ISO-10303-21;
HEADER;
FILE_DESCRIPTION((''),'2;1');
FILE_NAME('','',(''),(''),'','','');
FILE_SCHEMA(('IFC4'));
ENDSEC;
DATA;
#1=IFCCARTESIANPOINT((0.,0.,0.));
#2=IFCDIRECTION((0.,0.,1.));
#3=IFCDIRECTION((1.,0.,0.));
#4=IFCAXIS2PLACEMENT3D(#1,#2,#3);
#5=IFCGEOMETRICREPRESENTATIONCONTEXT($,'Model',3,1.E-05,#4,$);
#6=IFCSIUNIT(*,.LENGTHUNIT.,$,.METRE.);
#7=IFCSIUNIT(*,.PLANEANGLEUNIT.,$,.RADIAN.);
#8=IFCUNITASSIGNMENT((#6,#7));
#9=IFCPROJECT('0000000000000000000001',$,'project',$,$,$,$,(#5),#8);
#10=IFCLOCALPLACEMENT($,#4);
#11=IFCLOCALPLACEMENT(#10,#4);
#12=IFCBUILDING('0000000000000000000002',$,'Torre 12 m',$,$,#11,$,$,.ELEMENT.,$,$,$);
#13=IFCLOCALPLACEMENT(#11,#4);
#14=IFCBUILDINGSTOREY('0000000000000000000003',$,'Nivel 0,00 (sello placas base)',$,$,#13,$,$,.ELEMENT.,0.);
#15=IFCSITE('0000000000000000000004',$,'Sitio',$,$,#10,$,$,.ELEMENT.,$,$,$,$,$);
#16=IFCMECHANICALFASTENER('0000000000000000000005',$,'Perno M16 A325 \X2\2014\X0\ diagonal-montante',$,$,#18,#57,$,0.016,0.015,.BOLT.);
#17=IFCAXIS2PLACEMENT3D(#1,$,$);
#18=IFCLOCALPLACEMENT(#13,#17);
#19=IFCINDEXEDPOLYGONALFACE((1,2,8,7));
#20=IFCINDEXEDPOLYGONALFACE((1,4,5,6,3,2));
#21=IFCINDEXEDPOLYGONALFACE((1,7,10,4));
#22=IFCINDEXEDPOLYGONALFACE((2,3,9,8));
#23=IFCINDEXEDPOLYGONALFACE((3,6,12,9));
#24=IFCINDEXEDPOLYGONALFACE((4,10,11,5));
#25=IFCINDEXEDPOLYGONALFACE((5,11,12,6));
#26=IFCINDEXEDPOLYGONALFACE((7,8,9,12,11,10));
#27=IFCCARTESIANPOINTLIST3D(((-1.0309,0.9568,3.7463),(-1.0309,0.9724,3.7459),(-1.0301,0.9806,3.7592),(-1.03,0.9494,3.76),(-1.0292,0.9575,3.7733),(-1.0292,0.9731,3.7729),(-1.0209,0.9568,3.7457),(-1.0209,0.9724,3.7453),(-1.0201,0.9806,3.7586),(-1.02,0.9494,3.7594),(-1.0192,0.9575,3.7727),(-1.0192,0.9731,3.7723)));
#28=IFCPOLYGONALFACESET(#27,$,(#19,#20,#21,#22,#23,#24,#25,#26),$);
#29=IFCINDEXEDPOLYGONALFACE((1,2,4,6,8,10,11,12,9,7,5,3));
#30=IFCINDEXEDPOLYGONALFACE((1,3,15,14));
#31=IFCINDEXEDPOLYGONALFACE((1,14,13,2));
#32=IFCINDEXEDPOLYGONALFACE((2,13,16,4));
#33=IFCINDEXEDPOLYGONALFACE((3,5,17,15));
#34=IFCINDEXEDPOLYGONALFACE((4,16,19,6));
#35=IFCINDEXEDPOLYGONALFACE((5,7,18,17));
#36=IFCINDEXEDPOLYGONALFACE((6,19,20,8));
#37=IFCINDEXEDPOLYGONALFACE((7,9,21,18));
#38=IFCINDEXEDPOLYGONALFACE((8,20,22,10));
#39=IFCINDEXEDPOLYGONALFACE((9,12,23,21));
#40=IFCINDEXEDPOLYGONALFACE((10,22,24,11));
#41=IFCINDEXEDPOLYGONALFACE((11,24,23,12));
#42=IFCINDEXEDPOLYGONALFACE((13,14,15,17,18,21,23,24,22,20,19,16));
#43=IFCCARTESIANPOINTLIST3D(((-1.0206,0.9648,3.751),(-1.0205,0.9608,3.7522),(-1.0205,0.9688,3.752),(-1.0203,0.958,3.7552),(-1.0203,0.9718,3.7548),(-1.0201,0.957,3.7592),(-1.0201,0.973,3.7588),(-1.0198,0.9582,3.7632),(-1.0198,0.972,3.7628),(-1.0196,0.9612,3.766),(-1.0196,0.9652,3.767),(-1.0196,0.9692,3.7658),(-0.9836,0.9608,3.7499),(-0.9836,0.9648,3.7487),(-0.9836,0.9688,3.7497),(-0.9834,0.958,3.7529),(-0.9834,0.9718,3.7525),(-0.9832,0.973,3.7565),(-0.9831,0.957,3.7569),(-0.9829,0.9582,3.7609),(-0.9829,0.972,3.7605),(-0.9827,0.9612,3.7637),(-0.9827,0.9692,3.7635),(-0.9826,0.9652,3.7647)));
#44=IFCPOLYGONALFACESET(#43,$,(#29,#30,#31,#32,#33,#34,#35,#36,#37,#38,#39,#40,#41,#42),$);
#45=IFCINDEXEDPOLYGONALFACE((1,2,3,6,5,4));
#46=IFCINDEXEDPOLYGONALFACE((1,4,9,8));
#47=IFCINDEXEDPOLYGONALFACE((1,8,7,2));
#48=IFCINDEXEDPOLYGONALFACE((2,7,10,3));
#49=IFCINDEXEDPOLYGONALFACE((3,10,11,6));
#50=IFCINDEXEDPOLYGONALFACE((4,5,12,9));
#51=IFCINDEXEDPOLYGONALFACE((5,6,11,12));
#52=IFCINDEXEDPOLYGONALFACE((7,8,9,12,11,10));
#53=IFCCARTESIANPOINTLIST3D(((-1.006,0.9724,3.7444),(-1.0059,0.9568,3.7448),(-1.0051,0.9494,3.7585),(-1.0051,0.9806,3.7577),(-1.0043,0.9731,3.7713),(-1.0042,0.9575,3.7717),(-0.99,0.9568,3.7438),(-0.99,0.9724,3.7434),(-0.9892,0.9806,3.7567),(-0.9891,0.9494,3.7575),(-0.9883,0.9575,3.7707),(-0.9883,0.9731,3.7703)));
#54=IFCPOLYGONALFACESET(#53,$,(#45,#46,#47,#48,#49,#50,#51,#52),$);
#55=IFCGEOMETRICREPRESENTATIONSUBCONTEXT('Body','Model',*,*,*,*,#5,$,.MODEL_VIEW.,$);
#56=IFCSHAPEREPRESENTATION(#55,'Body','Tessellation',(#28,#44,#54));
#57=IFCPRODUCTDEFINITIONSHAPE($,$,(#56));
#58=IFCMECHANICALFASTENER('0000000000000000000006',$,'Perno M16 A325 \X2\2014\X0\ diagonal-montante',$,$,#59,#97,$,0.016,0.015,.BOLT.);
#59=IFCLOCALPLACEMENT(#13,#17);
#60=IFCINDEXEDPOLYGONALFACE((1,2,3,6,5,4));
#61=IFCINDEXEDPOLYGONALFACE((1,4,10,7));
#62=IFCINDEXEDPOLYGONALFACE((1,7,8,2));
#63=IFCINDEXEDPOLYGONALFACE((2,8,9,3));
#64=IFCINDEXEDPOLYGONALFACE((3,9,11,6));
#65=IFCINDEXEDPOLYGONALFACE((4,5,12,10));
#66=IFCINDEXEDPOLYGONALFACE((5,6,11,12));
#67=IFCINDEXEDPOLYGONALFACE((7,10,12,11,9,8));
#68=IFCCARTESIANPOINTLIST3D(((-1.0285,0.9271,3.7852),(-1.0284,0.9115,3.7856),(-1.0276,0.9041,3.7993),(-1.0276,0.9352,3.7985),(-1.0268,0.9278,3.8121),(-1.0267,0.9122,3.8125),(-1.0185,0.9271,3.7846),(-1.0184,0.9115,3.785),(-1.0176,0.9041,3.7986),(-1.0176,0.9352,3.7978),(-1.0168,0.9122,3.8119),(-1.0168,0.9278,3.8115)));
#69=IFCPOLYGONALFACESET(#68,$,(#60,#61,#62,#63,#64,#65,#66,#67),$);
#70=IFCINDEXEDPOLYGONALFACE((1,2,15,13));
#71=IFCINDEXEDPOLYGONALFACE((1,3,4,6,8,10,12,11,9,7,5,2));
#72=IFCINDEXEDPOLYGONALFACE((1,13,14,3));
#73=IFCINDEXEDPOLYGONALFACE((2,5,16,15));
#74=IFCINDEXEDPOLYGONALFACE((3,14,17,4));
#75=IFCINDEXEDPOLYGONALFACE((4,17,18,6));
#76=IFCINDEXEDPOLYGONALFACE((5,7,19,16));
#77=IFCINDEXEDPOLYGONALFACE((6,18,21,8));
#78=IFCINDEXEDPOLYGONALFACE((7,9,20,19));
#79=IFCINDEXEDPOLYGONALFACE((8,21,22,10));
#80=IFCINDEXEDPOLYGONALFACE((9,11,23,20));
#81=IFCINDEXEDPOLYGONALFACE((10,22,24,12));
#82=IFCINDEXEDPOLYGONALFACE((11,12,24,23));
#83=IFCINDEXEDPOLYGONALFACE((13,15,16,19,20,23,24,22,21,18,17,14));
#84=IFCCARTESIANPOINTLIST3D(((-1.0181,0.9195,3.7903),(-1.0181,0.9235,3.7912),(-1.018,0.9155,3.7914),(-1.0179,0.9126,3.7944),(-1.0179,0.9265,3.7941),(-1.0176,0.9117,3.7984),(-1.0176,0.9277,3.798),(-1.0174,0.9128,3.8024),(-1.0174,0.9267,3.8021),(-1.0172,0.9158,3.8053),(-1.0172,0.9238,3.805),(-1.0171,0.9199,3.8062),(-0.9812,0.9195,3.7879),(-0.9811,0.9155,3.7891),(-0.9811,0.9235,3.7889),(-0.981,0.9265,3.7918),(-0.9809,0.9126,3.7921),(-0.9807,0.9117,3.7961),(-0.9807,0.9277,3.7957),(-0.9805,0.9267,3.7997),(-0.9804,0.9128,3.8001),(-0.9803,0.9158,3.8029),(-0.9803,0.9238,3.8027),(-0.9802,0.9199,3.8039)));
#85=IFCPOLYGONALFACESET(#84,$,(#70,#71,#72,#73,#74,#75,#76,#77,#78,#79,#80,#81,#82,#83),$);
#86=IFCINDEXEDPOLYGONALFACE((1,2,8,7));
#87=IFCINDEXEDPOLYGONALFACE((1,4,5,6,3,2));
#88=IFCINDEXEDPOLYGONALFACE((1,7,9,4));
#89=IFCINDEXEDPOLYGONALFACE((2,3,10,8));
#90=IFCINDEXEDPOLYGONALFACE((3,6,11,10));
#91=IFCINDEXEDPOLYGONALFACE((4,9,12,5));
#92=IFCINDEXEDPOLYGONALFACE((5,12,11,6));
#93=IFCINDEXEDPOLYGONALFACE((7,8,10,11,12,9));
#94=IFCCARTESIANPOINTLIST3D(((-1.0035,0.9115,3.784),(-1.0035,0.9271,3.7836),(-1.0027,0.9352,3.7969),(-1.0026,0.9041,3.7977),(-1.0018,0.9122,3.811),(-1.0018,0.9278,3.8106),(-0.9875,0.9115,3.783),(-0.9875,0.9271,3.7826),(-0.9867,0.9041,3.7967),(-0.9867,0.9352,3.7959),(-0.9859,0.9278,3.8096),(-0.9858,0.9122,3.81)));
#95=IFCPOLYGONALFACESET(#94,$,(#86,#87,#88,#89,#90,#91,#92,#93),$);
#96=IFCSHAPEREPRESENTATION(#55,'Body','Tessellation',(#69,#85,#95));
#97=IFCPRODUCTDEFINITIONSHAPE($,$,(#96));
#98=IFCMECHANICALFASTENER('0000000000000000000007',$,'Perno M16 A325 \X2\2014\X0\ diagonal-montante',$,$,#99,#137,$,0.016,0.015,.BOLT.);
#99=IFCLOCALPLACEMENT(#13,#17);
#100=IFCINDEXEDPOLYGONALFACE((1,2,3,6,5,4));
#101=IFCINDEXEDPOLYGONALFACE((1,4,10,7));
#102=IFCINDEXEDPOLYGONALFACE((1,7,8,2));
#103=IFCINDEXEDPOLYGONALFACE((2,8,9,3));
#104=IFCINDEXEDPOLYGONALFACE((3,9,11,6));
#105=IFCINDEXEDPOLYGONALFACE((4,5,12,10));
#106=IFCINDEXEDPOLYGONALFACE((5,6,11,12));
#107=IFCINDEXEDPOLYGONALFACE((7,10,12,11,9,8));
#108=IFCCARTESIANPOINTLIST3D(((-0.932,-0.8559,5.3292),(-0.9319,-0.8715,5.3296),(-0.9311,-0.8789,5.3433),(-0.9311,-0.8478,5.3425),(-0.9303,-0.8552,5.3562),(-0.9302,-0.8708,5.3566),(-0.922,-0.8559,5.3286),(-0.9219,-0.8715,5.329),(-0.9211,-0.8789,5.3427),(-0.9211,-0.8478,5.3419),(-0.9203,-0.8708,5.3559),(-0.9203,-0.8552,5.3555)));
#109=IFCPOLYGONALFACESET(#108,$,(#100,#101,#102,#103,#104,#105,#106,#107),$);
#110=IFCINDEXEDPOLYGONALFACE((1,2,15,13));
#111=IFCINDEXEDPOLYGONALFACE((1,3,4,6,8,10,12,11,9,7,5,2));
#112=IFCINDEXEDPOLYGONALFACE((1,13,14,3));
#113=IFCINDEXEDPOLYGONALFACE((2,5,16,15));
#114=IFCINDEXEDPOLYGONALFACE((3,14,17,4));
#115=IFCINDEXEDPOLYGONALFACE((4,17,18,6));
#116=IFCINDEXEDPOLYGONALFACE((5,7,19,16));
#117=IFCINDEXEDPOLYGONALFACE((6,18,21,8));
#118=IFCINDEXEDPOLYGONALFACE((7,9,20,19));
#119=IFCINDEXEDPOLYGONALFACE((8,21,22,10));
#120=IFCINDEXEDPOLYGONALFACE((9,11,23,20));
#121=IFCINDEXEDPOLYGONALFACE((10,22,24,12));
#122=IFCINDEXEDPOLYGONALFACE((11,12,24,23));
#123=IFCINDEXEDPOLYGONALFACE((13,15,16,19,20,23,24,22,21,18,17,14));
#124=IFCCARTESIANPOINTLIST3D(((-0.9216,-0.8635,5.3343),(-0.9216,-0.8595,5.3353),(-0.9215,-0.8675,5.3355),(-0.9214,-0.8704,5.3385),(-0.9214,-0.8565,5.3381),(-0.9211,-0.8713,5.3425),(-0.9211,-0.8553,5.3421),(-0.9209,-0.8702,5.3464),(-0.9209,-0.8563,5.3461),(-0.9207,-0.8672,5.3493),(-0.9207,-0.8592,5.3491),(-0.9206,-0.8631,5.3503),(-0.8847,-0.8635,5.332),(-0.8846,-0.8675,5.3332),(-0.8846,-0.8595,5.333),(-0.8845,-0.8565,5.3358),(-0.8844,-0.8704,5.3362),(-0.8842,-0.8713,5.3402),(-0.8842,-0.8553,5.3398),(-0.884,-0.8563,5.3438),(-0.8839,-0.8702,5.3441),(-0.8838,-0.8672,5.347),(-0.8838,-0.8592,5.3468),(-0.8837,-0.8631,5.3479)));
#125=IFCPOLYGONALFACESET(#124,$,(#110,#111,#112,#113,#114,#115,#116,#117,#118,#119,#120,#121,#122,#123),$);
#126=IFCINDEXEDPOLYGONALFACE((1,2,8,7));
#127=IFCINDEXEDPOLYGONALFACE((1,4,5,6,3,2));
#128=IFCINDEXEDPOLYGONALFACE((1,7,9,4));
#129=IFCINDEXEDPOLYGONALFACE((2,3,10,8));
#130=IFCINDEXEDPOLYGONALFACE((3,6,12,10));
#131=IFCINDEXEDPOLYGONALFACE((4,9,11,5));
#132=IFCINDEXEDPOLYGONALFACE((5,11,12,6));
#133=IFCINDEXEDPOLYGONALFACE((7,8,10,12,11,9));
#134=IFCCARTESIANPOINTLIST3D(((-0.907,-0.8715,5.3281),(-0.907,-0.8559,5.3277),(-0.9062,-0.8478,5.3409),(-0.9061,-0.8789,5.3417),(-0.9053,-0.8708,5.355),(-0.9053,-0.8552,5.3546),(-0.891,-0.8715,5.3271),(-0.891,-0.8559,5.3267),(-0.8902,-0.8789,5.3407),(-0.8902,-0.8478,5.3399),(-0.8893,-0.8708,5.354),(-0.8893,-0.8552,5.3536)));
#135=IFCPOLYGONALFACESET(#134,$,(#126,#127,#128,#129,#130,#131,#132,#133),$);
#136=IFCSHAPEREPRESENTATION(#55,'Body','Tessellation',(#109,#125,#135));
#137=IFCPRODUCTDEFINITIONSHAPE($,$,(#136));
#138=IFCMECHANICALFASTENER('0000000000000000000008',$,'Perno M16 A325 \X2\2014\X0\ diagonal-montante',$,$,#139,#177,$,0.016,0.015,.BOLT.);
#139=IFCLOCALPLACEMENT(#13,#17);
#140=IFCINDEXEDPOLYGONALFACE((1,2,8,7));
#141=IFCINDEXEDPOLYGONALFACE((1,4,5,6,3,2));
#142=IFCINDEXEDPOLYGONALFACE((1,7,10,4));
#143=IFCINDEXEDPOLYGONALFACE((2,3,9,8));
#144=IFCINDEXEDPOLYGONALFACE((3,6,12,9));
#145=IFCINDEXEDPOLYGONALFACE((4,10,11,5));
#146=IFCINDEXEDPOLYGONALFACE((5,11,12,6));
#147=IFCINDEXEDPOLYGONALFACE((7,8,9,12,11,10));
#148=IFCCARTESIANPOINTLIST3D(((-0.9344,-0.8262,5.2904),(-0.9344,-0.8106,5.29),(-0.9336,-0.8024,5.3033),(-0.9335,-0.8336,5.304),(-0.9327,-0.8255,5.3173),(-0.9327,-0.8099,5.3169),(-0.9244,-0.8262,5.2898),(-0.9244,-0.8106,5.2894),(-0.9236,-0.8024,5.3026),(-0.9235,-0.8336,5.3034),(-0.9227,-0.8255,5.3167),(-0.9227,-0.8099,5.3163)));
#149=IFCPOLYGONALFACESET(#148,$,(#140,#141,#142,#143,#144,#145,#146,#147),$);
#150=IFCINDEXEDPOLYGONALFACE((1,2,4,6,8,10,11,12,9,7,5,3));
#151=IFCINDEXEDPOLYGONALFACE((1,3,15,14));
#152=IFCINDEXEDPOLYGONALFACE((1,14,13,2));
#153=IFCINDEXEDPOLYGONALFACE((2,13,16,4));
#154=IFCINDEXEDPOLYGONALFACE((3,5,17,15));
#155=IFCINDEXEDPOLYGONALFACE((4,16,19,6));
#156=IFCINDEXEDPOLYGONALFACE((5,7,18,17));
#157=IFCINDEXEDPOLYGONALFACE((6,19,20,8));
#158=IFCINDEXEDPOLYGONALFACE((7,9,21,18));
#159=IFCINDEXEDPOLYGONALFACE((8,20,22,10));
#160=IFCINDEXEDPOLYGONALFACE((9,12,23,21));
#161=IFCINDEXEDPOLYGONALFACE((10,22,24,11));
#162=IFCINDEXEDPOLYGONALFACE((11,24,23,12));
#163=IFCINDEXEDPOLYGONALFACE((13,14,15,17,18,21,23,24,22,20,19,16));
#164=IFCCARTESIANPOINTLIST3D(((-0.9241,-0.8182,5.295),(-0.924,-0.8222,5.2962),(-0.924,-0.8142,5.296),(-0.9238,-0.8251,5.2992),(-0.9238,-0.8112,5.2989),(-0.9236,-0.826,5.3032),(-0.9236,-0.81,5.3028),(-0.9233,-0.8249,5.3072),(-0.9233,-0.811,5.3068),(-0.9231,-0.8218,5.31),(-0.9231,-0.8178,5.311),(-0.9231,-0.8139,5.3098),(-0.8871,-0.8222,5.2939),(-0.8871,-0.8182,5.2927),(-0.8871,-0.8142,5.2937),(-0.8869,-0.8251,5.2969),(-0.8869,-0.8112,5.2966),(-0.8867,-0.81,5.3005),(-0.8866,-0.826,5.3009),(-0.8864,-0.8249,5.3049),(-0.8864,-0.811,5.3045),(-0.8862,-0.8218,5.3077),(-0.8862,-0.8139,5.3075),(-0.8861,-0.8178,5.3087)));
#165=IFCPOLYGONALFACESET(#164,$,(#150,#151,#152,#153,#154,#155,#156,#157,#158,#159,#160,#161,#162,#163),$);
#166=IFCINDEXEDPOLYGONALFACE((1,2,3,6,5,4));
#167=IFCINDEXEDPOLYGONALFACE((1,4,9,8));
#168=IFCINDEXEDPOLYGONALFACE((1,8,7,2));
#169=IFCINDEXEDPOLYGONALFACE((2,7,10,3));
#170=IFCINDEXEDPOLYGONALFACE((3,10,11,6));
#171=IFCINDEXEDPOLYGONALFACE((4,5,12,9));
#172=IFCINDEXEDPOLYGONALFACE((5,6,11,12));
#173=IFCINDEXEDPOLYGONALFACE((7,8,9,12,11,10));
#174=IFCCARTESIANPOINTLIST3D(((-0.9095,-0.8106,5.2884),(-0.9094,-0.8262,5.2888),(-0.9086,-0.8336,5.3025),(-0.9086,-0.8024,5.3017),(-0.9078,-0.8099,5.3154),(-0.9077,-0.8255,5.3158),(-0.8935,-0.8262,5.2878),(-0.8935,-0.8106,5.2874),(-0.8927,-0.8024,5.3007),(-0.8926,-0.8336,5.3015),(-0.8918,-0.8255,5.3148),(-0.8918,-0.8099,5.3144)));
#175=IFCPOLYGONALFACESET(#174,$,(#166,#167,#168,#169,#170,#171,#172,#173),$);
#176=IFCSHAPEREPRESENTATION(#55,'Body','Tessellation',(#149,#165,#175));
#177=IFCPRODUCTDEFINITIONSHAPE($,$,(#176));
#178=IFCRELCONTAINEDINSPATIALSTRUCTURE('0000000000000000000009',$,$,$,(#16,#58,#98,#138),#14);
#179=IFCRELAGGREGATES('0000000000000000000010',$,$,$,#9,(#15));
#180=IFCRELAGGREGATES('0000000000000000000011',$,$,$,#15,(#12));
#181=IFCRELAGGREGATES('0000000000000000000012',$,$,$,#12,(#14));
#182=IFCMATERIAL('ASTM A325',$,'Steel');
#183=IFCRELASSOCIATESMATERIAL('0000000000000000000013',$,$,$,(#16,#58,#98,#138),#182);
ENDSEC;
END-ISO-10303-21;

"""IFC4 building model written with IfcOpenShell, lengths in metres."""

from ifc_helpers import new_model, si_unit, frame, origin_with_axes, place, context, subcontext, project, spatial, polyline, outline, extrude, material, element, save


model = new_model("IFC4")

# Units and contexts
model_context = context("Model", 3, precision=1e-05, world=origin_with_axes())
body_context = subcontext(model_context, "Body", "Model", "MODEL_VIEW")
ifc_project = project(units=[si_unit("LENGTHUNIT", "METRE"), si_unit("PLANEANGLEUNIT", "RADIAN")], contexts=[model_context])

# Site, building, storey
site_placement = place(None, origin_with_axes())
site = spatial("IfcSite", under=ifc_project, at=site_placement, Name="Sitio", CompositionType="ELEMENT")
building_placement = place(site_placement, origin_with_axes())
building = spatial("IfcBuilding", under=site, at=building_placement, Name="Torre 12 m", CompositionType="ELEMENT")
storey_placement = place(building_placement, origin_with_axes())
storey = spatial("IfcBuildingStorey", under=building, at=storey_placement, Name="Nivel 0,00 (sello placas base)", CompositionType="ELEMENT", Elevation=0.0)

# Shared definitions
placement = place(storey_placement, origin_with_axes())

# Mechanical fasteners
ifc_material_1 = material(Name="ASTM A325", Category="Steel")
element("IfcMechanicalFastener", 1, at=placement, inside=storey, material=ifc_material_1, Name="Perno M16 A325 — diagonal-montante", NominalDiameter=0.016, NominalLength=0.015, PredefinedType="BOLT", context=body_context, shape_type="SweptSolid", body=[
    extrude(outline(polyline([(0.0135, 0.0078), (0.0, 0.0156), (-0.0135, 0.0078), (-0.0135, -0.0078), (0.0, -0.0156), (0.0135, -0.0078), (0.0135, 0.0078)])), frame((-1.0301, 0.965, 3.7596), z_axis=(0.998053, 0.0, -0.062378), x_axis=(0.032557, -0.85299, 0.52091)), (0.0, 0.0, 1.0), 0.01),
    extrude(outline(polyline([(0.008, 0.0), (0.0069, 0.004), (0.004, 0.0069), (0.0, 0.008), (-0.004, 0.0069), (-0.0069, 0.004), (-0.008, 0.0), (-0.0069, -0.004), (-0.004, -0.0069), (0.0, -0.008), (0.004, -0.0069), (0.0069, -0.004), (0.008, 0.0)])), frame((-1.0201, 0.965, 3.759), z_axis=(0.998053, 0.0, -0.062378), x_axis=(0.032557, -0.85299, 0.52091)), (0.0, 0.0, 1.0), 0.037),
    extrude(outline(polyline([(0.0135, 0.0078), (0.0, 0.0156), (-0.0135, 0.0078), (-0.0135, -0.0078), (0.0, -0.0156), (0.0135, -0.0078), (0.0135, 0.0078)])), frame((-1.0051, 0.965, 3.7581), z_axis=(0.998053, 0.0, -0.062378), x_axis=(0.032557, -0.85299, 0.52091)), (0.0, 0.0, 1.0), 0.016),
])
element("IfcMechanicalFastener", 2, at=placement, inside=storey, material=ifc_material_1, Name="Perno M16 A325 — diagonal-montante", NominalDiameter=0.016, NominalLength=0.015, PredefinedType="BOLT", context=body_context, shape_type="SweptSolid", body=[
    extrude(outline(polyline([(0.0135, 0.0078), (0.0, 0.0156), (-0.0135, 0.0078), (-0.0135, -0.0078), (0.0, -0.0156), (0.0135, -0.0078), (0.0135, 0.0078)])), frame((-1.0276, 0.9197, 3.7989), z_axis=(0.998053, 0.0, -0.062378), x_axis=(0.032557, -0.85299, 0.52091)), (0.0, 0.0, 1.0), 0.01),
    extrude(outline(polyline([(0.008, 0.0), (0.0069, 0.004), (0.004, 0.0069), (0.0, 0.008), (-0.004, 0.0069), (-0.0069, 0.004), (-0.008, 0.0), (-0.0069, -0.004), (-0.004, -0.0069), (0.0, -0.008), (0.004, -0.0069), (0.0069, -0.004), (0.008, 0.0)])), frame((-1.0176, 0.9197, 3.7982), z_axis=(0.998053, 0.0, -0.062378), x_axis=(0.032557, -0.85299, 0.52091)), (0.0, 0.0, 1.0), 0.037),
    extrude(outline(polyline([(0.0135, 0.0078), (0.0, 0.0156), (-0.0135, 0.0078), (-0.0135, -0.0078), (0.0, -0.0156), (0.0135, -0.0078), (0.0135, 0.0078)])), frame((-1.0026, 0.9197, 3.7973), z_axis=(0.998053, 0.0, -0.062378), x_axis=(0.032557, -0.85299, 0.52091)), (0.0, 0.0, 1.0), 0.016),
])
element("IfcMechanicalFastener", 3, at=placement, inside=storey, material=ifc_material_1, Name="Perno M16 A325 — diagonal-montante", NominalDiameter=0.016, NominalLength=0.015, PredefinedType="BOLT", context=body_context, shape_type="SweptSolid", body=[
    extrude(outline(polyline([(0.0135, 0.0078), (0.0, 0.0156), (-0.0135, 0.0078), (-0.0135, -0.0078), (0.0, -0.0156), (0.0135, -0.0078), (0.0135, 0.0078)])), frame((-0.9311, -0.8633, 5.3429), z_axis=(0.998053, 0.0, -0.062378), x_axis=(0.032557, -0.85299, 0.52091)), (0.0, 0.0, 1.0), 0.01),
    extrude(outline(polyline([(0.008, 0.0), (0.0069, 0.004), (0.004, 0.0069), (0.0, 0.008), (-0.004, 0.0069), (-0.0069, 0.004), (-0.008, 0.0), (-0.0069, -0.004), (-0.004, -0.0069), (0.0, -0.008), (0.004, -0.0069), (0.0069, -0.004), (0.008, 0.0)])), frame((-0.9211, -0.8633, 5.3423), z_axis=(0.998053, 0.0, -0.062378), x_axis=(0.032557, -0.85299, 0.52091)), (0.0, 0.0, 1.0), 0.037),
    extrude(outline(polyline([(0.0135, 0.0078), (0.0, 0.0156), (-0.0135, 0.0078), (-0.0135, -0.0078), (0.0, -0.0156), (0.0135, -0.0078), (0.0135, 0.0078)])), frame((-0.9061, -0.8633, 5.3413), z_axis=(0.998053, 0.0, -0.062378), x_axis=(0.032557, -0.85299, 0.52091)), (0.0, 0.0, 1.0), 0.016),
])
element("IfcMechanicalFastener", 4, at=placement, inside=storey, material=ifc_material_1, Name="Perno M16 A325 — diagonal-montante", NominalDiameter=0.016, NominalLength=0.015, PredefinedType="BOLT", context=body_context, shape_type="SweptSolid", body=[
    extrude(outline(polyline([(0.0135, 0.0078), (0.0, 0.0156), (-0.0135, 0.0078), (-0.0135, -0.0078), (0.0, -0.0156), (0.0135, -0.0078), (0.0135, 0.0078)])), frame((-0.9336, -0.818, 5.3037), z_axis=(0.998053, 0.0, -0.062378), x_axis=(0.032557, -0.85299, 0.52091)), (0.0, 0.0, 1.0), 0.01),
    extrude(outline(polyline([(0.008, 0.0), (0.0069, 0.004), (0.004, 0.0069), (0.0, 0.008), (-0.004, 0.0069), (-0.0069, 0.004), (-0.008, 0.0), (-0.0069, -0.004), (-0.004, -0.0069), (0.0, -0.008), (0.004, -0.0069), (0.0069, -0.004), (0.008, 0.0)])), frame((-0.9236, -0.818, 5.303), z_axis=(0.998053, 0.0, -0.062378), x_axis=(0.032557, -0.85299, 0.52091)), (0.0, 0.0, 1.0), 0.037),
    extrude(outline(polyline([(0.0135, 0.0078), (0.0, 0.0156), (-0.0135, 0.0078), (-0.0135, -0.0078), (0.0, -0.0156), (0.0135, -0.0078), (0.0135, 0.0078)])), frame((-0.9086, -0.818, 5.3021), z_axis=(0.998053, 0.0, -0.062378), x_axis=(0.032557, -0.85299, 0.52091)), (0.0, 0.0, 1.0), 0.016),
])

save(model, "model.ifc")
